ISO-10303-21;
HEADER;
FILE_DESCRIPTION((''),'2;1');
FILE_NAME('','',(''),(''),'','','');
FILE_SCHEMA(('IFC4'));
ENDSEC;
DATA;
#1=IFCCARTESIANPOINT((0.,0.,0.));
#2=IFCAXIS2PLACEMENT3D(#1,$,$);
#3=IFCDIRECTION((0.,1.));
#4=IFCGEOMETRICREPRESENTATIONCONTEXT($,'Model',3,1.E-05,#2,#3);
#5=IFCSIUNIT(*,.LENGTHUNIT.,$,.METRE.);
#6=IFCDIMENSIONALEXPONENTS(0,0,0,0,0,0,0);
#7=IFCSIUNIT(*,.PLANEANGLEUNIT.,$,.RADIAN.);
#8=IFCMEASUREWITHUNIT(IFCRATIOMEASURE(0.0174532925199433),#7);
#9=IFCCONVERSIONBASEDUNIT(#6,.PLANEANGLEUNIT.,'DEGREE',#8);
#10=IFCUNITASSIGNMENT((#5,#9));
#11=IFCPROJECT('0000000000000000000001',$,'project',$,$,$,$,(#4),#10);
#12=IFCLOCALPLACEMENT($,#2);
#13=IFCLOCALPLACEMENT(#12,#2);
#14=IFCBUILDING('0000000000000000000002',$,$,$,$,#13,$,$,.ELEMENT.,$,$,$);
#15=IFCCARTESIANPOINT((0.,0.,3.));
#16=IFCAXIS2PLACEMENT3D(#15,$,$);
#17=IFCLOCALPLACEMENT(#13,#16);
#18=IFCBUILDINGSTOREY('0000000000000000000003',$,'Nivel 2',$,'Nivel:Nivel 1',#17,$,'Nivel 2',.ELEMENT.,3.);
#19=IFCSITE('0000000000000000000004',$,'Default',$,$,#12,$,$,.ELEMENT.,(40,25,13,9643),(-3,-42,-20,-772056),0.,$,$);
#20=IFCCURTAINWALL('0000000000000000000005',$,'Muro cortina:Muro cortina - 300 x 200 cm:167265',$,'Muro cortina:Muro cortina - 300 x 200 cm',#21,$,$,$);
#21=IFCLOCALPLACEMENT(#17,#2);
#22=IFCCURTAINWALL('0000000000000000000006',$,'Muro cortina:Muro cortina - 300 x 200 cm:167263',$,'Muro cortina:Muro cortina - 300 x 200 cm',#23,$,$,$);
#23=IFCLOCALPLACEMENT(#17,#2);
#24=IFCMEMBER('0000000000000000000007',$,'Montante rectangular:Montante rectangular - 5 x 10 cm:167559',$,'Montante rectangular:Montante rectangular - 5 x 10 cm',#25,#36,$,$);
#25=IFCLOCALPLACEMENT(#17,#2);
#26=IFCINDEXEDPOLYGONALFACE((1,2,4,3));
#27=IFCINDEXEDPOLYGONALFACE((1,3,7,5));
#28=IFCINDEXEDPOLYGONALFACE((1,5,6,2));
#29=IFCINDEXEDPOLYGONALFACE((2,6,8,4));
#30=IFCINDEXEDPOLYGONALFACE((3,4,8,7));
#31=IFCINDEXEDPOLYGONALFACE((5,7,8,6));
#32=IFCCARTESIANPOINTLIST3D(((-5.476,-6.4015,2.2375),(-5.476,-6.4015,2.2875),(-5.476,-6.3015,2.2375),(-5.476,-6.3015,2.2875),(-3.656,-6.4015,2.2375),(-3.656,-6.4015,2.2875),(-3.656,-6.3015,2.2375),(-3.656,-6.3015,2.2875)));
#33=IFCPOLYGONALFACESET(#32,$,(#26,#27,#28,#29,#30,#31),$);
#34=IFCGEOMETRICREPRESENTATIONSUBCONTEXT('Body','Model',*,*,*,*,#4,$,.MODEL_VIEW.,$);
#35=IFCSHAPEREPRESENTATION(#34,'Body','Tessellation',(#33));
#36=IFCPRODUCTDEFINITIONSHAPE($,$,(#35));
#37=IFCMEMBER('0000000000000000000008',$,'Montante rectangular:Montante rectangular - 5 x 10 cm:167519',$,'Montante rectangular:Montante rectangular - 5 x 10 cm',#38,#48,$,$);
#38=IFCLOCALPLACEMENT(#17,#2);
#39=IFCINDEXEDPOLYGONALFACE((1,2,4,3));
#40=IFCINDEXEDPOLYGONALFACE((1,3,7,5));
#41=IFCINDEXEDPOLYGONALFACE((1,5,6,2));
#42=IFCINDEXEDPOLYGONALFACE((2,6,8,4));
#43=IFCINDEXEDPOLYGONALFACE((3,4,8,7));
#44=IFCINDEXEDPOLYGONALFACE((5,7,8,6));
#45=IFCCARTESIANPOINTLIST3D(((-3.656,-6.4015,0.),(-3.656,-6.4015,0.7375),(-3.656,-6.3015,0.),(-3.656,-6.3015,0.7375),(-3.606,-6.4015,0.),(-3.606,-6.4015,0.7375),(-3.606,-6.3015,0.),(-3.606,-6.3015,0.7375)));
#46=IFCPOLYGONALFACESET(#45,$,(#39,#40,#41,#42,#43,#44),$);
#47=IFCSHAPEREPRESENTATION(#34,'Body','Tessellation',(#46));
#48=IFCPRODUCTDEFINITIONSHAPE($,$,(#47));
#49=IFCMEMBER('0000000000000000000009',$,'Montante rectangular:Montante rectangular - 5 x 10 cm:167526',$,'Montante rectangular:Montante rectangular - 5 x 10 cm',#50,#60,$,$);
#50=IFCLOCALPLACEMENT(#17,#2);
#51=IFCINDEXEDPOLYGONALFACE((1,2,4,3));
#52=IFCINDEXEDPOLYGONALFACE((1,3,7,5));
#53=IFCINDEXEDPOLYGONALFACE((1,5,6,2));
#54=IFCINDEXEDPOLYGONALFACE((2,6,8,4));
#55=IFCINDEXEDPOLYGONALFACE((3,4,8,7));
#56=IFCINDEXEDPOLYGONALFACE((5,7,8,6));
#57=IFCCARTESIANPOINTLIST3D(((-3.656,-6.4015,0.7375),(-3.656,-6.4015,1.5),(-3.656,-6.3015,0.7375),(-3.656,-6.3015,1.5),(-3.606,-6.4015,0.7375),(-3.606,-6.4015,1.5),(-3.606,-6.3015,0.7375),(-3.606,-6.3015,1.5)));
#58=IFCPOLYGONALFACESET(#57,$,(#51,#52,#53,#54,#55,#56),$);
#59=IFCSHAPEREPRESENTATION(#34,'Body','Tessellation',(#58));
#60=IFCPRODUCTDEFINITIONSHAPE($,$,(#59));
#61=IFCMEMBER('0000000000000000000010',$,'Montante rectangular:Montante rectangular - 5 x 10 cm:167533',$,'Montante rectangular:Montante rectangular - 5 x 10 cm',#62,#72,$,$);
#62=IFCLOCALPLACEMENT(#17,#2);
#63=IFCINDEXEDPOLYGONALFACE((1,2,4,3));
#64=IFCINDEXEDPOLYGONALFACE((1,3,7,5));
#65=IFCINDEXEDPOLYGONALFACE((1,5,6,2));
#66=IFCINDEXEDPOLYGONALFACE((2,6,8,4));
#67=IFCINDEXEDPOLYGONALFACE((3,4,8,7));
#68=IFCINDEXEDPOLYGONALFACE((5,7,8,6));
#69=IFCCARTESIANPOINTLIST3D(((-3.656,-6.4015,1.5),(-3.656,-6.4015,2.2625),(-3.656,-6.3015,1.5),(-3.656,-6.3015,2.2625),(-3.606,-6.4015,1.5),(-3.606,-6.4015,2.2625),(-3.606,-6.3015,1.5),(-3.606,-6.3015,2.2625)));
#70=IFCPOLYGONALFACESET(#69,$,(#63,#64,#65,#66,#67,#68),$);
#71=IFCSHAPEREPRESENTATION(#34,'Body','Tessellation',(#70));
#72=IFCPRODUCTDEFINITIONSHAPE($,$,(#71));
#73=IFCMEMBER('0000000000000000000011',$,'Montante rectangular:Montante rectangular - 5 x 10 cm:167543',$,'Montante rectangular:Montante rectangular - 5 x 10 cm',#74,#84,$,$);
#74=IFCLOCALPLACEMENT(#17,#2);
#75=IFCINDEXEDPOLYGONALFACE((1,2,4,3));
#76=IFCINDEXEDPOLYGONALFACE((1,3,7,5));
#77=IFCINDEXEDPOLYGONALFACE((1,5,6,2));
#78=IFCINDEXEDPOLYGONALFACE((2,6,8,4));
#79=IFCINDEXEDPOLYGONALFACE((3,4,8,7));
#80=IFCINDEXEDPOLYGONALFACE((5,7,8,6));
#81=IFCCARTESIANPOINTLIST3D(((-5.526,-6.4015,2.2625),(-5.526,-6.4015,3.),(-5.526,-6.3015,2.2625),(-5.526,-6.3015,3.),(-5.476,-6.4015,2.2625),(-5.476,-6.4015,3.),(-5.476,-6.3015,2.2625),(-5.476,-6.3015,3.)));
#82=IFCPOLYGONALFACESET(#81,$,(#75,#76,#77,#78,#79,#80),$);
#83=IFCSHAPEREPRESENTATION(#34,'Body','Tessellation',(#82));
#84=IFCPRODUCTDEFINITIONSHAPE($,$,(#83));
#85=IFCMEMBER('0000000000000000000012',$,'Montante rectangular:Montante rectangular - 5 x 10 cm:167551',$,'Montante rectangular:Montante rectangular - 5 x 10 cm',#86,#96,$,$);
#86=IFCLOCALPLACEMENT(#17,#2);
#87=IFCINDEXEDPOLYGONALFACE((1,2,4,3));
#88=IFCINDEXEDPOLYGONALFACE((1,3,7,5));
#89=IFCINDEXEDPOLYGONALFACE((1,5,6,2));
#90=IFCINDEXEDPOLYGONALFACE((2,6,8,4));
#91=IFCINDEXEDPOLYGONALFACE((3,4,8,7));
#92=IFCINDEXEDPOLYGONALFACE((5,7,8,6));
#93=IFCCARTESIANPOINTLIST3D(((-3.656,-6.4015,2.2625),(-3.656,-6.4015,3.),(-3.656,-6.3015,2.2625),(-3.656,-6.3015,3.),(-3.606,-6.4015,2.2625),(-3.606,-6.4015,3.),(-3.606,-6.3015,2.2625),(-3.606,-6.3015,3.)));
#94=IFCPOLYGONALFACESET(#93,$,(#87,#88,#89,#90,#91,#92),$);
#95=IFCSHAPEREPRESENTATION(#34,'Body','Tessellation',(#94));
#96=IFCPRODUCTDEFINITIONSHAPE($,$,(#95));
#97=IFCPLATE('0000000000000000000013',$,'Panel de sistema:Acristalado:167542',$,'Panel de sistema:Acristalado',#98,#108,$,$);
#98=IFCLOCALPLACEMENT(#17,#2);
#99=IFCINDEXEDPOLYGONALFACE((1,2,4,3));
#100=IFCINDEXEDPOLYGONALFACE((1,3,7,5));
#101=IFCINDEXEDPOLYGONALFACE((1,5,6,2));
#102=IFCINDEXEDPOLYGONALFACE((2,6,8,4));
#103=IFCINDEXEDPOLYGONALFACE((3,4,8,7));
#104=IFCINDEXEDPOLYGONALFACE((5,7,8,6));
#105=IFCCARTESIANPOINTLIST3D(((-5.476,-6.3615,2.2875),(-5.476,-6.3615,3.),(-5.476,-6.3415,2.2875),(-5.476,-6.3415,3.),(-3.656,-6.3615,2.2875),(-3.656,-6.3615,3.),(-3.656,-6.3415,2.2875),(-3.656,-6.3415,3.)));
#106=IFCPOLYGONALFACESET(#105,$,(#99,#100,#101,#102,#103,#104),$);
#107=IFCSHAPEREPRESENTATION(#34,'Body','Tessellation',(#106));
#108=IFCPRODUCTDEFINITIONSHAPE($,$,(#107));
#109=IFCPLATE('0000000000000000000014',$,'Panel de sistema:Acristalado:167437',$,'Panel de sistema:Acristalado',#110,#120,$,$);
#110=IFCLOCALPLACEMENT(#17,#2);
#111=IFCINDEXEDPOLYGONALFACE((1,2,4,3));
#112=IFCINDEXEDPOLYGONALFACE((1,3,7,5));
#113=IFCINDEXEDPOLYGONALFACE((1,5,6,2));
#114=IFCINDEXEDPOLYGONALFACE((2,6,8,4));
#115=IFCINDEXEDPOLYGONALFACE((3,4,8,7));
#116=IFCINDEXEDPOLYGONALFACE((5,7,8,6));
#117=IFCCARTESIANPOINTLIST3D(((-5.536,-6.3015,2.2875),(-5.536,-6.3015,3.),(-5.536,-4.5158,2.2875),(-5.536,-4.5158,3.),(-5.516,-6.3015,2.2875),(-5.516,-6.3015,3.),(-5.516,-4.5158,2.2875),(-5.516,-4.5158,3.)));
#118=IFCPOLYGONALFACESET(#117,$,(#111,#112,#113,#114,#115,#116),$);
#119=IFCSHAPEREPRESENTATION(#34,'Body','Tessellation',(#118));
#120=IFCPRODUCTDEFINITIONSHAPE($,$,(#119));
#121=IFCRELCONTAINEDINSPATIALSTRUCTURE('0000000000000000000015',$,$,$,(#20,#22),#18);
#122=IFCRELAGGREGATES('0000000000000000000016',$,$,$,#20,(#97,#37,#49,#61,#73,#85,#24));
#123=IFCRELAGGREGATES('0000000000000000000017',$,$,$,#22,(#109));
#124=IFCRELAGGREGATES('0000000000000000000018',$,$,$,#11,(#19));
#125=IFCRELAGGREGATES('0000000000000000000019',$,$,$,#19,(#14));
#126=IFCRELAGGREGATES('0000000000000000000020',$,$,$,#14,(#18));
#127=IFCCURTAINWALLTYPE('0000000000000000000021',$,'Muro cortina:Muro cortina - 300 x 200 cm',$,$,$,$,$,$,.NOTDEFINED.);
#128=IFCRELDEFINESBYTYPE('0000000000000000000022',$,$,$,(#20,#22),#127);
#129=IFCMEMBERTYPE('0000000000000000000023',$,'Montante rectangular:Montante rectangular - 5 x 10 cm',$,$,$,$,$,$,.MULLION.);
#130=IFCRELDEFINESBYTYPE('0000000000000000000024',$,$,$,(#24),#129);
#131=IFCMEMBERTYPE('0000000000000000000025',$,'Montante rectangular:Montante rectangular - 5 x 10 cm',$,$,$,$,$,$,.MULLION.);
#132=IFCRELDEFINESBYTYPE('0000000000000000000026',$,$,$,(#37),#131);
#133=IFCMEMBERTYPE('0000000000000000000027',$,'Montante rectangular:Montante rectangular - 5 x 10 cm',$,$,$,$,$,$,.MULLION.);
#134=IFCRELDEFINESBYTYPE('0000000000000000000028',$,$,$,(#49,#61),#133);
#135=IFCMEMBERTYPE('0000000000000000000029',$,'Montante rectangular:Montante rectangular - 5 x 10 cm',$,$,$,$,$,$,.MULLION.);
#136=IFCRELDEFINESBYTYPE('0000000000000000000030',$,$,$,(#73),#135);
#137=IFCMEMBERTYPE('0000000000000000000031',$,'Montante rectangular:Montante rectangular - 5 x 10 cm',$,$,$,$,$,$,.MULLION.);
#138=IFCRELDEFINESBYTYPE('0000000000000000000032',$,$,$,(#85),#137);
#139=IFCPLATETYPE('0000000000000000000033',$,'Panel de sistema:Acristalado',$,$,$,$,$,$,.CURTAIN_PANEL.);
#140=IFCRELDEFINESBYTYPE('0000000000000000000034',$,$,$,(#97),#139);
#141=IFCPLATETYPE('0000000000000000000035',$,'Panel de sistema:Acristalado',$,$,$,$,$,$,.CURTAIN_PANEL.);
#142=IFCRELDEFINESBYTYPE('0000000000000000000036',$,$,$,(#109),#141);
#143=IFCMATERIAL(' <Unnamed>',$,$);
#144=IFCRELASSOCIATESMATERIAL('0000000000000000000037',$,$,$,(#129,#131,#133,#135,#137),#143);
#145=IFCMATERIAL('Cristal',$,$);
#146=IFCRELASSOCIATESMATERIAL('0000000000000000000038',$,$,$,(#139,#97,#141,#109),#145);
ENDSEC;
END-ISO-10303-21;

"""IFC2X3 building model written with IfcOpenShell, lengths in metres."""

from ifc_helpers import new_model, entity, si_unit, converted_unit, direction, frame, origin, origin_2d_with_axis, place, context, subcontext, project, spatial, rectangle, extrude, source, transform, mapped, material, type_object, type_shapes, element, aggregate, save


model = new_model("IFC2X3")

# Units and contexts
model_context = context("Model", 3, precision=1e-05, world=origin(), true_north=direction((0.0, 1.0)))
body_context = subcontext(model_context, "Body", "Model", "MODEL_VIEW")
ifc_project = project(units=[si_unit("LENGTHUNIT", "METRE"), converted_unit("PLANEANGLEUNIT", "DEGREE", entity("IfcRatioMeasure", 0.0174532925199433), si_unit("PLANEANGLEUNIT", "RADIAN"), dimensions=[0, 0, 0, 0, 0, 0, 0])], contexts=[model_context])

# Site, building, storey
site_placement = place(None, origin())
site = spatial("IfcSite", under=ifc_project, at=site_placement, Name="Default", CompositionType="ELEMENT", RefLatitude=(40, 25, 13, 9643), RefLongitude=(-3, -42, -20, -772056), RefElevation=0.0)
building_placement = place(site_placement, origin())
building = spatial("IfcBuilding", under=site, at=building_placement, CompositionType="ELEMENT")
storey_placement = place(building_placement, frame((0.0, 0.0, 3.0)))
storey = spatial("IfcBuildingStorey", under=building, at=storey_placement, Name="Nivel 2", ObjectType="Nivel:Nivel 1", LongName="Nivel 2", CompositionType="ELEMENT", Elevation=3.0)

# Curtain walls
curtain_wall_type = type_object("IfcCurtainWallType", Name="Muro cortina:Muro cortina - 300 x 200 cm", PredefinedType="NOTDEFINED")
curtain_wall_1_placement = place(storey_placement, frame((0.0, 0.0, -3.0)))
curtain_wall_1 = element("IfcCurtainWall", 1, at=curtain_wall_1_placement, inside=storey, type_object=curtain_wall_type, Name="Muro cortina:Muro cortina - 300 x 200 cm:167265", ObjectType="Muro cortina:Muro cortina - 300 x 200 cm")
ifc_material_1 = material(Name=" <Unnamed>")
curtain_wall_2_placement = place(storey_placement, frame((0.0, 0.0, -3.0)))
curtain_wall_2 = element("IfcCurtainWall", 2, at=curtain_wall_2_placement, inside=storey, type_object=curtain_wall_type, Name="Muro cortina:Muro cortina - 300 x 200 cm:167263", ObjectType="Muro cortina:Muro cortina - 300 x 200 cm")

# Members
member_type_1 = type_object("IfcMemberType", Name="Montante rectangular:Montante rectangular - 5 x 10 cm", PredefinedType="MULLION", material=ifc_material_1)
shared_shape_1 = source(origin(), body_context, "Body", "SweptSolid", [
    extrude(rectangle(XDim=0.1, YDim=0.05, at=origin_2d_with_axis()), frame((0.0, 0.0, -1.82), z_axis=(0.0, 0.0, 1.0), x_axis=(0.0, -1.0, 0.0)), (0.0, 0.0, 1.0), 1.82),
])
type_shapes(member_type_1, [shared_shape_1])
member_1_placement = place(storey_placement, frame((-5.476, -6.3515, 2.2625), z_axis=(-1.0, 0.0, 0.0), x_axis=(0.0, 0.0, 1.0)))
member_1 = element("IfcMember", 3, at=member_1_placement, type_object=member_type_1, Name="Montante rectangular:Montante rectangular - 5 x 10 cm:167559", ObjectType="Montante rectangular:Montante rectangular - 5 x 10 cm", context=body_context, shape_type="MappedRepresentation", body=[
    mapped(shared_shape_1, transform((0.0, 0.0, 0.0), scale=1.0)),
])
member_type_2 = type_object("IfcMemberType", Name="Montante rectangular:Montante rectangular - 5 x 10 cm", PredefinedType="MULLION", material=ifc_material_1)
shared_shape_2 = source(origin(), body_context, "Body", "SweptSolid", [
    extrude(rectangle(XDim=0.1, YDim=0.05, at=origin_2d_with_axis()), frame((0.0, 0.0, -0.7375), z_axis=(0.0, 0.0, 1.0), x_axis=(0.0, -1.0, 0.0)), (0.0, 0.0, 1.0), 0.7375),
])
type_shapes(member_type_2, [shared_shape_2])
member_2_placement = place(storey_placement, frame((-3.631, -6.3515, 0.0), z_axis=(0.0, 0.0, -1.0), x_axis=(-1.0, 0.0, 0.0)))
member_2 = element("IfcMember", 4, at=member_2_placement, type_object=member_type_2, Name="Montante rectangular:Montante rectangular - 5 x 10 cm:167519", ObjectType="Montante rectangular:Montante rectangular - 5 x 10 cm", context=body_context, shape_type="MappedRepresentation", body=[
    mapped(shared_shape_2, transform((0.0, 0.0, 0.0), scale=1.0)),
])
member_type_3 = type_object("IfcMemberType", Name="Montante rectangular:Montante rectangular - 5 x 10 cm", PredefinedType="MULLION", material=ifc_material_1)
shared_shape_3 = source(origin(), body_context, "Body", "SweptSolid", [
    extrude(rectangle(XDim=0.1, YDim=0.05, at=origin_2d_with_axis()), frame((0.0, 0.0, -0.7625), z_axis=(0.0, 0.0, 1.0), x_axis=(0.0, -1.0, 0.0)), (0.0, 0.0, 1.0), 0.7625),
])
type_shapes(member_type_3, [shared_shape_3])
member_3_placement = place(storey_placement, frame((-3.631, -6.3515, 0.7375), z_axis=(0.0, 0.0, -1.0), x_axis=(-1.0, 0.0, 0.0)))
member_3 = element("IfcMember", 5, at=member_3_placement, type_object=member_type_3, Name="Montante rectangular:Montante rectangular - 5 x 10 cm:167526", ObjectType="Montante rectangular:Montante rectangular - 5 x 10 cm", context=body_context, shape_type="MappedRepresentation", body=[
    mapped(shared_shape_3, transform((0.0, 0.0, 0.0), scale=1.0)),
])
member_4_placement = place(storey_placement, frame((-3.631, -6.3515, 1.5), z_axis=(0.0, 0.0, -1.0), x_axis=(-1.0, 0.0, 0.0)))
member_4 = element("IfcMember", 6, at=member_4_placement, type_object=member_type_3, Name="Montante rectangular:Montante rectangular - 5 x 10 cm:167533", ObjectType="Montante rectangular:Montante rectangular - 5 x 10 cm", context=body_context, shape_type="MappedRepresentation", body=[
    mapped(shared_shape_3, transform((0.0, 0.0, 0.0), scale=1.0)),
])
member_type_4 = type_object("IfcMemberType", Name="Montante rectangular:Montante rectangular - 5 x 10 cm", PredefinedType="MULLION", material=ifc_material_1)
shared_shape_4 = source(origin(), body_context, "Body", "SweptSolid", [
    extrude(rectangle(XDim=0.1, YDim=0.05, at=origin_2d_with_axis()), frame((-0.025, 0.0, -0.7375), z_axis=(0.0, 0.0, 1.0), x_axis=(0.0, -1.0, 0.0)), (0.0, 0.0, 1.0), 0.7375),
])
type_shapes(member_type_4, [shared_shape_4])
member_5_placement = place(storey_placement, frame((-5.526, -6.3515, 2.2625), z_axis=(0.0, 0.0, -1.0), x_axis=(-1.0, 0.0, 0.0)))
member_5 = element("IfcMember", 7, at=member_5_placement, type_object=member_type_4, Name="Montante rectangular:Montante rectangular - 5 x 10 cm:167543", ObjectType="Montante rectangular:Montante rectangular - 5 x 10 cm", context=body_context, shape_type="MappedRepresentation", body=[
    mapped(shared_shape_4, transform((0.0, 0.0, 0.0), scale=1.0)),
])
member_type_5 = type_object("IfcMemberType", Name="Montante rectangular:Montante rectangular - 5 x 10 cm", PredefinedType="MULLION", material=ifc_material_1)
shared_shape_5 = source(origin(), body_context, "Body", "SweptSolid", [
    extrude(rectangle(XDim=0.1, YDim=0.05, at=origin_2d_with_axis()), frame((0.0, 0.0, -0.7375), z_axis=(0.0, 0.0, 1.0), x_axis=(0.0, -1.0, 0.0)), (0.0, 0.0, 1.0), 0.7375),
])
type_shapes(member_type_5, [shared_shape_5])
member_6_placement = place(storey_placement, frame((-3.631, -6.3515, 2.2625), z_axis=(0.0, 0.0, -1.0), x_axis=(-1.0, 0.0, 0.0)))
member_6 = element("IfcMember", 8, at=member_6_placement, type_object=member_type_5, Name="Montante rectangular:Montante rectangular - 5 x 10 cm:167551", ObjectType="Montante rectangular:Montante rectangular - 5 x 10 cm", context=body_context, shape_type="MappedRepresentation", body=[
    mapped(shared_shape_5, transform((0.0, 0.0, 0.0), scale=1.0)),
])

# Plates
ifc_material_2 = material(Name="Cristal")
plate_type_1 = type_object("IfcPlateType", Name="Panel de sistema:Acristalado", PredefinedType="CURTAIN_PANEL", material=ifc_material_2)
shared_shape_6 = source(origin(), body_context, "Body", "SweptSolid", [
    extrude(rectangle(XDim=0.02, YDim=1.82, at=origin_2d_with_axis()), frame((0.0, 0.0, 0.0), z_axis=(0.0, 0.0, 1.0), x_axis=(0.0, 1.0, 0.0)), (0.0, 0.0, 1.0), 0.7125),
])
type_shapes(plate_type_1, [shared_shape_6])
plate_1_placement = place(curtain_wall_1_placement, frame((-4.566, -6.3515, 5.2875), z_axis=(0.0, 0.0, 1.0), x_axis=(-1.0, 0.0, 0.0)))
plate_1 = element("IfcPlate", 9, at=plate_1_placement, type_object=plate_type_1, material=ifc_material_2, Name="Panel de sistema:Acristalado:167542", ObjectType="Panel de sistema:Acristalado", context=body_context, shape_type="MappedRepresentation", body=[
    mapped(shared_shape_6, transform((0.0, 0.0, 0.0), scale=1.0)),
])
aggregate(curtain_wall_1, [plate_1, member_2, member_3, member_4, member_5, member_6, member_1])
plate_type_2 = type_object("IfcPlateType", Name="Panel de sistema:Acristalado", PredefinedType="CURTAIN_PANEL", material=ifc_material_2)
shared_shape_7 = source(origin(), body_context, "Body", "SweptSolid", [
    extrude(rectangle(XDim=0.02, YDim=1.7857, at=origin_2d_with_axis()), frame((0.0, 0.0, 0.0), z_axis=(0.0, 0.0, 1.0), x_axis=(0.0, 1.0, 0.0)), (0.0, 0.0, 1.0), 0.7125),
])
type_shapes(plate_type_2, [shared_shape_7])
plate_2_placement = place(curtain_wall_2_placement, frame((-5.526, -5.4087, 5.2875), z_axis=(0.0, 0.0, 1.0), x_axis=(0.0, 1.0, 0.0)))
plate_2 = element("IfcPlate", 10, at=plate_2_placement, type_object=plate_type_2, material=ifc_material_2, Name="Panel de sistema:Acristalado:167437", ObjectType="Panel de sistema:Acristalado", context=body_context, shape_type="MappedRepresentation", body=[
    mapped(shared_shape_7, transform((0.0, 0.0, 0.0), scale=1.0)),
])
aggregate(curtain_wall_2, [plate_2])

save(model, "model.ifc")
